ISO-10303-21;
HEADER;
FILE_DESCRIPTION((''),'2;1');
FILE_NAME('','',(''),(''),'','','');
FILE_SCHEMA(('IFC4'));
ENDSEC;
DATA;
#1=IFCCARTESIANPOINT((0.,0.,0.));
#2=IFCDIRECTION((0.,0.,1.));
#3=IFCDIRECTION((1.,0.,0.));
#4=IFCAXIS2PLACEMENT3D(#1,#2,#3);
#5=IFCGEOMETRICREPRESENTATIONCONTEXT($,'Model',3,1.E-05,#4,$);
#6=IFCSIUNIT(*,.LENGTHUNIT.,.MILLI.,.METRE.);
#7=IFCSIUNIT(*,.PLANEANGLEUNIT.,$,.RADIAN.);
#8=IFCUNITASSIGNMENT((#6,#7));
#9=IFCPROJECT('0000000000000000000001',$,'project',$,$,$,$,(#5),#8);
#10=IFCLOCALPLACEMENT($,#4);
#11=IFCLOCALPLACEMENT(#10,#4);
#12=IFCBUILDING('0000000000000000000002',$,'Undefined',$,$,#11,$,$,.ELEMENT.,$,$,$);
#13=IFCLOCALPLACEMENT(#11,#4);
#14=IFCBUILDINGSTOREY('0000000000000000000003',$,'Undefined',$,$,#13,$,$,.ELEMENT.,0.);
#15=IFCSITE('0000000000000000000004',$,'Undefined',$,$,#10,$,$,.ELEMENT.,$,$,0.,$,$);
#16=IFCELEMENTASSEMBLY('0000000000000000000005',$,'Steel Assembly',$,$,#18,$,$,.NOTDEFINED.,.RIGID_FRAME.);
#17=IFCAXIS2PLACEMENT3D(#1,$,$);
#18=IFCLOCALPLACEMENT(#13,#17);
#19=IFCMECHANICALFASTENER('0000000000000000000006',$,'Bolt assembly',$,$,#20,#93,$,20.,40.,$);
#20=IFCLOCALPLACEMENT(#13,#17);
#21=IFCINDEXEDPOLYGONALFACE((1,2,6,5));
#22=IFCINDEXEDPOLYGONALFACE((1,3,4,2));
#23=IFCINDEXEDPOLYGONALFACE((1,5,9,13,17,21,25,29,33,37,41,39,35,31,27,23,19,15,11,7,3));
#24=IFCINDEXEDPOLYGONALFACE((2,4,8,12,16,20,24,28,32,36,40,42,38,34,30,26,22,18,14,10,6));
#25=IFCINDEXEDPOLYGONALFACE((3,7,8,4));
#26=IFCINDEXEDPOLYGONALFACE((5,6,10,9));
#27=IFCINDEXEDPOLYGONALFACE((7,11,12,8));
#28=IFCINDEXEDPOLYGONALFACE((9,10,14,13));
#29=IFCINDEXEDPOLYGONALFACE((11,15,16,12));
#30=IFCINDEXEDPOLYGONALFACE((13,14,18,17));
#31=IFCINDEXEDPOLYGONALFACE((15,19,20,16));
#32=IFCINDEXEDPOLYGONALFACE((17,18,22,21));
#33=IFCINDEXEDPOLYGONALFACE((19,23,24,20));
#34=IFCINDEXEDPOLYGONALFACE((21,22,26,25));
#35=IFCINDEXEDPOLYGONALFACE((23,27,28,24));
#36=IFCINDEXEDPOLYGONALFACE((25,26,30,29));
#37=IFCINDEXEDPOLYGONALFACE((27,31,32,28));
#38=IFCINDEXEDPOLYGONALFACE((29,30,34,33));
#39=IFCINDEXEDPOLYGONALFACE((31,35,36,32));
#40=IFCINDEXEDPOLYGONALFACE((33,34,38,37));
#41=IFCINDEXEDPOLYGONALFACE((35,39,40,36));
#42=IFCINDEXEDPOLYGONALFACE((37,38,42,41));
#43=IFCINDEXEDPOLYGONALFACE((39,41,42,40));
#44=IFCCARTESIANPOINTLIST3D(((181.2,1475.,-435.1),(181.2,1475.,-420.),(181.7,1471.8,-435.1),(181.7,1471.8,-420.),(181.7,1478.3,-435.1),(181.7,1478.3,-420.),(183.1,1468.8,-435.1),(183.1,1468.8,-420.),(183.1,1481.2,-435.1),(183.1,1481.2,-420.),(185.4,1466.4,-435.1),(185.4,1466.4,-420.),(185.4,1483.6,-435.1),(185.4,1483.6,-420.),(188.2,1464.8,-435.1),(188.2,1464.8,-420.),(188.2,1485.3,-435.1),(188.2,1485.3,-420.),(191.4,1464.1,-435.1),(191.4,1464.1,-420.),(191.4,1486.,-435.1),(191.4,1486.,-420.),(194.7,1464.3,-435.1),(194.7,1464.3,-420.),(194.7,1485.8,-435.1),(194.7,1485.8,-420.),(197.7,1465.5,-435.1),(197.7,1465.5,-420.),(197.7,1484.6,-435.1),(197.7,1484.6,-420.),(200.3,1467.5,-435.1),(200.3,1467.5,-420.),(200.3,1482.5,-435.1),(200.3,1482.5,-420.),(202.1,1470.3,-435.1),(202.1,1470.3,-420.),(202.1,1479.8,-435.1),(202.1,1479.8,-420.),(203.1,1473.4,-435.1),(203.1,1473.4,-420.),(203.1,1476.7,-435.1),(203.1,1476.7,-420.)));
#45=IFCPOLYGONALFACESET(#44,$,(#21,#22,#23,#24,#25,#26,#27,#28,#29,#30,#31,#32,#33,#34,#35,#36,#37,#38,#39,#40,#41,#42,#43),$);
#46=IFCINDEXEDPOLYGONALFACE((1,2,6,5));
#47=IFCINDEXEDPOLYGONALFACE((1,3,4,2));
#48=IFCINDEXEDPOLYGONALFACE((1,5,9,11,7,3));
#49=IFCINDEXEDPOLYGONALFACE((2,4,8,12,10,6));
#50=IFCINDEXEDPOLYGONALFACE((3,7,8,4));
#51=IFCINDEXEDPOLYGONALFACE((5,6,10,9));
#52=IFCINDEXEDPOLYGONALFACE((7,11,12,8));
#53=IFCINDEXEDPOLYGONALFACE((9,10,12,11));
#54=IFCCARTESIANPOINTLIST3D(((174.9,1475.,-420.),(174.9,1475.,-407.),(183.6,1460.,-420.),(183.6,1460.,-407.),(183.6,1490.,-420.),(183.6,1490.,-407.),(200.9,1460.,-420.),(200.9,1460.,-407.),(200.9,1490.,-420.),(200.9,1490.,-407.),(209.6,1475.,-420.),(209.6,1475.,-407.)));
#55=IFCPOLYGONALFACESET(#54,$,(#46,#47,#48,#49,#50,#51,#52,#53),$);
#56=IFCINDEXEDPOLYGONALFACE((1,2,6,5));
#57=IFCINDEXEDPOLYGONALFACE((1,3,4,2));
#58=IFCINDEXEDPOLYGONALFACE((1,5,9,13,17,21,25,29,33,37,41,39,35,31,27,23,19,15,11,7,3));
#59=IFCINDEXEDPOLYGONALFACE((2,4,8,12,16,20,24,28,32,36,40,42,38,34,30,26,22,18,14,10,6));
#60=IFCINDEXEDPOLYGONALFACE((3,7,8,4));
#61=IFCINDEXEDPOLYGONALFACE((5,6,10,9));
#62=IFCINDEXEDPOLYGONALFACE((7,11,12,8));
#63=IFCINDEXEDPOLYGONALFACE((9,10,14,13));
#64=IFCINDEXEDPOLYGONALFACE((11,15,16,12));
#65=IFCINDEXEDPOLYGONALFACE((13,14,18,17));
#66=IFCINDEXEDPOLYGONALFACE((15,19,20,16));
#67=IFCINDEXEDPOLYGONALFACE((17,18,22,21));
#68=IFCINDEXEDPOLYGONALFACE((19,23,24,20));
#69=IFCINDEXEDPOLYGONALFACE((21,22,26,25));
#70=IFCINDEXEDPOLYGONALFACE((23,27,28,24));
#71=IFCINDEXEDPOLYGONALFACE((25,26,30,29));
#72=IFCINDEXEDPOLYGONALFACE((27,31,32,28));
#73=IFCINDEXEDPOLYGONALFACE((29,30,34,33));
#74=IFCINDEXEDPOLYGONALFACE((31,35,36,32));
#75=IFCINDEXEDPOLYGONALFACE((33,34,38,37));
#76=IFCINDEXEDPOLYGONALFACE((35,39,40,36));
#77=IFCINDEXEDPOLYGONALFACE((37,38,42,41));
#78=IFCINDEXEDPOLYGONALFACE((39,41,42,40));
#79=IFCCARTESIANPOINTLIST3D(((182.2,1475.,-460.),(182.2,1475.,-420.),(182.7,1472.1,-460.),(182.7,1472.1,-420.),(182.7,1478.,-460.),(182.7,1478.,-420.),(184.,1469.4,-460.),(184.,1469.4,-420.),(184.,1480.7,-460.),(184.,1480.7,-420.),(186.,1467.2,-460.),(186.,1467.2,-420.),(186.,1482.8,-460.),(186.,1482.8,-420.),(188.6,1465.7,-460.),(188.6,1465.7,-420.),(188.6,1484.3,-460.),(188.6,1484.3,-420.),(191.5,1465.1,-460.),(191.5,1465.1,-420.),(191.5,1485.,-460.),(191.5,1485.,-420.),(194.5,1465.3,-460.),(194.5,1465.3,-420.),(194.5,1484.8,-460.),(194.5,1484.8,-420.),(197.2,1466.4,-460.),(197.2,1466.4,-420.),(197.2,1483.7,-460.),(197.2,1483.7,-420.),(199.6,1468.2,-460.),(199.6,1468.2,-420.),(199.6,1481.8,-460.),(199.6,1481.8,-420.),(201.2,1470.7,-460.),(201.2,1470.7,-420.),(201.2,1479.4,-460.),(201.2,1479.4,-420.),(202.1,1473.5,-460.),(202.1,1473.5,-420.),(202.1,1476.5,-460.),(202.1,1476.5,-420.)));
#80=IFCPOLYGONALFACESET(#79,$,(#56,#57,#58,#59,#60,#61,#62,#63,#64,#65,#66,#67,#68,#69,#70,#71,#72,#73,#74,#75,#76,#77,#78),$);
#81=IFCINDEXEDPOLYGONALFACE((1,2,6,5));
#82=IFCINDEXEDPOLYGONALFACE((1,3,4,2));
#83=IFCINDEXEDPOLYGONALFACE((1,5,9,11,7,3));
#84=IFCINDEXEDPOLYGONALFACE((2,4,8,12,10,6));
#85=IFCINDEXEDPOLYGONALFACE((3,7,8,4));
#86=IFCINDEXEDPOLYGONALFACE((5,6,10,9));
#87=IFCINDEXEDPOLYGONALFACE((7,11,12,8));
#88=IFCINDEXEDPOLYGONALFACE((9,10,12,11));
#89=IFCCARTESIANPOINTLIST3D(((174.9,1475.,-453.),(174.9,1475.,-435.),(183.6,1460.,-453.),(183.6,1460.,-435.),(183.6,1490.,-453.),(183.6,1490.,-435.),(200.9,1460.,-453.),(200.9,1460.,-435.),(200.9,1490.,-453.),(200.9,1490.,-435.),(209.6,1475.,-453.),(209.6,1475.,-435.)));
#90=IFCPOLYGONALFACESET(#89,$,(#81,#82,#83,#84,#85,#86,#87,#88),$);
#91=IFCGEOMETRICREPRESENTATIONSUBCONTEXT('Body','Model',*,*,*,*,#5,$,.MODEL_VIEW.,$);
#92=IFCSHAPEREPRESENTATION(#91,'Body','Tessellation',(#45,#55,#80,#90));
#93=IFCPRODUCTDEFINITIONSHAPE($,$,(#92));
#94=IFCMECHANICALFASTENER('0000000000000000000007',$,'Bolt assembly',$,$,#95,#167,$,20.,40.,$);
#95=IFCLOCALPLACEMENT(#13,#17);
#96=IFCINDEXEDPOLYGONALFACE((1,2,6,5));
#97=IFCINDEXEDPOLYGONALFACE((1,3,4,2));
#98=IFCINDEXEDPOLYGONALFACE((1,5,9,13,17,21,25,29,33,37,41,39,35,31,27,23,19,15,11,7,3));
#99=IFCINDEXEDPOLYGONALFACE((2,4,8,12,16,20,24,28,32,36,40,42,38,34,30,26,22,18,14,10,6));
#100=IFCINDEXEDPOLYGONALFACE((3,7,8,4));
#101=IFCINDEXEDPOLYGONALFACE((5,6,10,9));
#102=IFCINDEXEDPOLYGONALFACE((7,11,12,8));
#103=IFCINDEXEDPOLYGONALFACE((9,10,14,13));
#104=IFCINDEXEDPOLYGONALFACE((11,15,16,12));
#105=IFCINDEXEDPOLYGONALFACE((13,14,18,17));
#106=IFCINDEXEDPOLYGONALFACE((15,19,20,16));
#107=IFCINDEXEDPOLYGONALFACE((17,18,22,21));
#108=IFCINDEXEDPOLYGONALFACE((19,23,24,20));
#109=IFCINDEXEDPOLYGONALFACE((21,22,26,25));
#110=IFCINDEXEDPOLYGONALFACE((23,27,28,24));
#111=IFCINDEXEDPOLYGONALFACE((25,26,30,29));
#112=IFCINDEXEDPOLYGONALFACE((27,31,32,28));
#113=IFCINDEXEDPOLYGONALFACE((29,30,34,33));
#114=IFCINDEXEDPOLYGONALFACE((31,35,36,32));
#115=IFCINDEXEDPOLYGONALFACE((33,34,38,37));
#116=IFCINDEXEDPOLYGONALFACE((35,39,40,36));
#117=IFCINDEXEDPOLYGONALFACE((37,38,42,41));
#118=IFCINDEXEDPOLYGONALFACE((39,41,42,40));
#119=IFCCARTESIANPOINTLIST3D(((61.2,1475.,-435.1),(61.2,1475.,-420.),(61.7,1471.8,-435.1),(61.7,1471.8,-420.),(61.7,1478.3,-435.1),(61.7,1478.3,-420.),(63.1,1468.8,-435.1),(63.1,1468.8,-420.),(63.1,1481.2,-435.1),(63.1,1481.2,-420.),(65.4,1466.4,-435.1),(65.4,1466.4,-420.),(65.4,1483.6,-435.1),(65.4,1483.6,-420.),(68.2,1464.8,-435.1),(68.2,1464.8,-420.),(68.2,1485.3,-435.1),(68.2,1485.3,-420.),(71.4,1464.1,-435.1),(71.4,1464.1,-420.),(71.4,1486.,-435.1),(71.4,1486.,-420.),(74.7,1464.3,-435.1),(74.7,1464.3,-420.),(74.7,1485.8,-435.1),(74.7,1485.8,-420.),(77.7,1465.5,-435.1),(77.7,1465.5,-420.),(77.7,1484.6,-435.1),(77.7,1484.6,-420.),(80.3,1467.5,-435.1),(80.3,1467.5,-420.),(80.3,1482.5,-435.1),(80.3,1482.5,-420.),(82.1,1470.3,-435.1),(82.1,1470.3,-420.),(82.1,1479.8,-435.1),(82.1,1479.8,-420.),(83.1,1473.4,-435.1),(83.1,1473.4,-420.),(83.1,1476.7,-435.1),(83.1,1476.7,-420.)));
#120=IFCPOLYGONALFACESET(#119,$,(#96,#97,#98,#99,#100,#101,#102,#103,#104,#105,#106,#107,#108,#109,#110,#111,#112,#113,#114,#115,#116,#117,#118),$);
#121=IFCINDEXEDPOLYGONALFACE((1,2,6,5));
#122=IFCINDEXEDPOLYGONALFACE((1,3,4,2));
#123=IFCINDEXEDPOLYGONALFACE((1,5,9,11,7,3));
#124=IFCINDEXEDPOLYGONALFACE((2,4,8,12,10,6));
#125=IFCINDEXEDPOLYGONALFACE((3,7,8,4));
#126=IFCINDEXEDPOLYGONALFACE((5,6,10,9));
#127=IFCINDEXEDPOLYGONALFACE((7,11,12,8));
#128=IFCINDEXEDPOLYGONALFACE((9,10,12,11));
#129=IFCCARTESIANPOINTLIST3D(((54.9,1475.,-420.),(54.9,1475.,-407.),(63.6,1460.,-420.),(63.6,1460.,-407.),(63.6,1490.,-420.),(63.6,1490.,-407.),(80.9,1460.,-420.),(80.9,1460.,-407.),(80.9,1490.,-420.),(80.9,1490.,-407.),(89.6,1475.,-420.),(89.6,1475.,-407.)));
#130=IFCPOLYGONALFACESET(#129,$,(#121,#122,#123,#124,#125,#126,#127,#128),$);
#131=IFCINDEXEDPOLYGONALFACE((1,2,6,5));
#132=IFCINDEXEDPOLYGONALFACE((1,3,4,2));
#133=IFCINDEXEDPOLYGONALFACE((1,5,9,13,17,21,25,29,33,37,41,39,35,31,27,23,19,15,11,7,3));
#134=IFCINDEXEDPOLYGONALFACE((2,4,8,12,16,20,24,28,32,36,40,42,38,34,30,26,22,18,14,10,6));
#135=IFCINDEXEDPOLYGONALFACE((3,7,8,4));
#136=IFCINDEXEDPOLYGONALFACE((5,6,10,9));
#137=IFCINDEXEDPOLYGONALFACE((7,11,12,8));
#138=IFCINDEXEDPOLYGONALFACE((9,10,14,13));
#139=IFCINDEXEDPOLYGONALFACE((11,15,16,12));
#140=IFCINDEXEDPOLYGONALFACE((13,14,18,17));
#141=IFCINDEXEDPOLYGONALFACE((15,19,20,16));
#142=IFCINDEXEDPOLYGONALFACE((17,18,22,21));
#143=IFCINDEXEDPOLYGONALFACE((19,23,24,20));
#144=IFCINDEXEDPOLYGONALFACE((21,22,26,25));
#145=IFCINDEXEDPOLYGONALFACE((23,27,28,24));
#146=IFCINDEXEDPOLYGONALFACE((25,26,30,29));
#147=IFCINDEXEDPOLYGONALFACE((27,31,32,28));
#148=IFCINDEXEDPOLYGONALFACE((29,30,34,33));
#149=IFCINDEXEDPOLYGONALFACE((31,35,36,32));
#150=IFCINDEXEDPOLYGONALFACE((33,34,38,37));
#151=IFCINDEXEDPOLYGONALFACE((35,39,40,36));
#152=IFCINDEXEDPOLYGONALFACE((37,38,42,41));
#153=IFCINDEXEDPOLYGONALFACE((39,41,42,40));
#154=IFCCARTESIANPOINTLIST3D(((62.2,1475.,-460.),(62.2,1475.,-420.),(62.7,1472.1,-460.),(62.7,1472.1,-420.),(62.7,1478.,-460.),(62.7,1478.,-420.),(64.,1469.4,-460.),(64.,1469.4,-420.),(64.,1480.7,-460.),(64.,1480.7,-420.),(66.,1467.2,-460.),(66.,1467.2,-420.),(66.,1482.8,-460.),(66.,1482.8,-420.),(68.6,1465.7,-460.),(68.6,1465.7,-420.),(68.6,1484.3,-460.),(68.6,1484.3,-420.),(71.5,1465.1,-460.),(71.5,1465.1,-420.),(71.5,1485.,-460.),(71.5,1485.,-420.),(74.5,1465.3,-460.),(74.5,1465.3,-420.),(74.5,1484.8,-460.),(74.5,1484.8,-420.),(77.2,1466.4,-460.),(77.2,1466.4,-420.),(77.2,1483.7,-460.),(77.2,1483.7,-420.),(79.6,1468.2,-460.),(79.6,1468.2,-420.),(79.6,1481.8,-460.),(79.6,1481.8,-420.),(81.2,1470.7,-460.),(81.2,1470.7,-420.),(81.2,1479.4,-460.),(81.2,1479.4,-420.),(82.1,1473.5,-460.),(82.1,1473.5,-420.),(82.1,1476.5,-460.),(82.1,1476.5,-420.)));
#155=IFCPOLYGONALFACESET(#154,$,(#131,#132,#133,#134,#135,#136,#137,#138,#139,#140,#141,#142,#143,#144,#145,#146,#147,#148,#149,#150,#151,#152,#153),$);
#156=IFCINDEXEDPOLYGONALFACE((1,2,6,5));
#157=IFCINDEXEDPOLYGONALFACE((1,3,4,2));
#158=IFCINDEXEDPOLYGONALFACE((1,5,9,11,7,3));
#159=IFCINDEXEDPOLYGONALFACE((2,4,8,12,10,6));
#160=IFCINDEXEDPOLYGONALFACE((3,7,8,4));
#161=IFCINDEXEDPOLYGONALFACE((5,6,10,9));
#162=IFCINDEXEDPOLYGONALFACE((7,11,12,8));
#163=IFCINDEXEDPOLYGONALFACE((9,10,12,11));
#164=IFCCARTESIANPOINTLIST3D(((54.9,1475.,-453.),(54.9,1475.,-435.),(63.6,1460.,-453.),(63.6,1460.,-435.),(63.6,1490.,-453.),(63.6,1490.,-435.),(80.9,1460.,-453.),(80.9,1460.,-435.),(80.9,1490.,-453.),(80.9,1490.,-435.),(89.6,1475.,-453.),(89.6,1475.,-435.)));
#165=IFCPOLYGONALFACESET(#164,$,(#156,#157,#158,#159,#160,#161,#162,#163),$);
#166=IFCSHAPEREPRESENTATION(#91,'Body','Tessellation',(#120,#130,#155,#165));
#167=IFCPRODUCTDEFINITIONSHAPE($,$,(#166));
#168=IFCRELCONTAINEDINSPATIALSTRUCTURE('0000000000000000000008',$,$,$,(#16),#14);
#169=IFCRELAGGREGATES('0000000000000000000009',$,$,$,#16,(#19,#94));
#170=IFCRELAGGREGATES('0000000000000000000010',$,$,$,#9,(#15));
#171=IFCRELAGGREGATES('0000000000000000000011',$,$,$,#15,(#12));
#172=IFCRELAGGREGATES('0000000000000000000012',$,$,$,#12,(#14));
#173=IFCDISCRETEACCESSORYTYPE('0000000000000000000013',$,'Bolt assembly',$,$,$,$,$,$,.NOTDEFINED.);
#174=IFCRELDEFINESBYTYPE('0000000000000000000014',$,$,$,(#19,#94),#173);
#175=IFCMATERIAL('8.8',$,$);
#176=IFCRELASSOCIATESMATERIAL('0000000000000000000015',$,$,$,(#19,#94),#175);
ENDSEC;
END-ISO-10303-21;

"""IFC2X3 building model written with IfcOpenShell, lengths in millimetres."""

from ifc_helpers import new_model, si_unit, frame, origin_with_axes, origin_2d_with_axis, place, context, subcontext, project, spatial, polyline, circle, outline, extrude, source, transform, mapped, material, type_object, element, aggregate, save


model = new_model("IFC2X3")

# Units and contexts
model_context = context("Model", 3, precision=1e-05, world=origin_with_axes())
body_context = subcontext(model_context, "Body", "Model", "MODEL_VIEW")
ifc_project = project(units=[si_unit("LENGTHUNIT", "METRE", prefix="MILLI"), si_unit("PLANEANGLEUNIT", "RADIAN")], contexts=[model_context])

# Site, building, storey
site_placement = place(None, origin_with_axes())
site = spatial("IfcSite", under=ifc_project, at=site_placement, Name="Undefined", CompositionType="ELEMENT", RefElevation=0.0)
building_placement = place(site_placement, origin_with_axes())
building = spatial("IfcBuilding", under=site, at=building_placement, Name="Undefined", CompositionType="ELEMENT")
storey_placement = place(building_placement, origin_with_axes())
storey = spatial("IfcBuildingStorey", under=building, at=storey_placement, Name="Undefined", CompositionType="ELEMENT", Elevation=0.0)

# Element assembly
assembly_1_placement = place(storey_placement, origin_with_axes())
assembly_1 = element("IfcElementAssembly", 1, at=assembly_1_placement, inside=storey, Name="Steel Assembly", AssemblyPlace="NOTDEFINED", PredefinedType="RIGID_FRAME")

# Mechanical fasteners
ifc_material_1 = material(Name="8.8")
discrete_accessory_type_1 = type_object("IfcDiscreteAccessoryType", Name="Bolt assembly")
shared_shape_1 = source(origin_with_axes(), body_context, "Body", "SweptSolid", [
    extrude(circle(Radius=11.0, at=origin_2d_with_axis()), frame((0.0, 0.0, 0.0), z_axis=(0.0, 1.0, 0.0), x_axis=(1.0, 0.0, 0.0)), (0.0, 0.0, 1.0), 15.1),
    extrude(outline(polyline([(17.3, 0.0), (8.7, 15.0), (-8.7, 15.0), (-17.3, 0.0), (-8.7, -15.0), (8.7, -15.0), (17.3, 0.0)])), frame((0.0, -13.0, 0.0), z_axis=(0.0, 1.0, 0.0), x_axis=(1.0, 0.0, 0.0)), (0.0, 0.0, 1.0), 13.0),
    extrude(circle(Radius=10.0, at=origin_2d_with_axis()), frame((0.0, 0.0, 0.0), z_axis=(0.0, 1.0, 0.0), x_axis=(1.0, 0.0, 0.0)), (0.0, 0.0, 1.0), 40.0),
    extrude(outline(polyline([(17.3, 0.0), (8.7, 15.0), (-8.7, 15.0), (-17.3, 0.0), (-8.7, -15.0), (8.7, -15.0), (17.3, 0.0)])), frame((0.0, 15.0, 0.0), z_axis=(0.0, 1.0, 0.0), x_axis=(1.0, 0.0, 0.0)), (0.0, 0.0, 1.0), 18.0),
])
mechanical_fastener_1_placement = place(assembly_1_placement, frame((192.2, 1475.0, -420.0), z_axis=(0.0, -1.0, 0.0), x_axis=(-1.0, 0.0, 0.0)))
mechanical_fastener_1 = element("IfcMechanicalFastener", 2, at=mechanical_fastener_1_placement, type_object=discrete_accessory_type_1, material=ifc_material_1, Name="Bolt assembly", NominalDiameter=20.0, NominalLength=40.0, context=body_context, shape_type="MappedRepresentation", body=[
    mapped(shared_shape_1, transform((0.0, 0.0, 0.0))),
])
mechanical_fastener_2_placement = place(assembly_1_placement, frame((72.2, 1475.0, -420.0), z_axis=(0.0, -1.0, 0.0), x_axis=(-1.0, 0.0, 0.0)))
mechanical_fastener_2 = element("IfcMechanicalFastener", 3, at=mechanical_fastener_2_placement, type_object=discrete_accessory_type_1, material=ifc_material_1, Name="Bolt assembly", NominalDiameter=20.0, NominalLength=40.0, context=body_context, shape_type="MappedRepresentation", body=[
    mapped(shared_shape_1, transform((0.0, 0.0, 0.0))),
])

aggregate(assembly_1, [mechanical_fastener_1, mechanical_fastener_2])

save(model, "model.ifc")
